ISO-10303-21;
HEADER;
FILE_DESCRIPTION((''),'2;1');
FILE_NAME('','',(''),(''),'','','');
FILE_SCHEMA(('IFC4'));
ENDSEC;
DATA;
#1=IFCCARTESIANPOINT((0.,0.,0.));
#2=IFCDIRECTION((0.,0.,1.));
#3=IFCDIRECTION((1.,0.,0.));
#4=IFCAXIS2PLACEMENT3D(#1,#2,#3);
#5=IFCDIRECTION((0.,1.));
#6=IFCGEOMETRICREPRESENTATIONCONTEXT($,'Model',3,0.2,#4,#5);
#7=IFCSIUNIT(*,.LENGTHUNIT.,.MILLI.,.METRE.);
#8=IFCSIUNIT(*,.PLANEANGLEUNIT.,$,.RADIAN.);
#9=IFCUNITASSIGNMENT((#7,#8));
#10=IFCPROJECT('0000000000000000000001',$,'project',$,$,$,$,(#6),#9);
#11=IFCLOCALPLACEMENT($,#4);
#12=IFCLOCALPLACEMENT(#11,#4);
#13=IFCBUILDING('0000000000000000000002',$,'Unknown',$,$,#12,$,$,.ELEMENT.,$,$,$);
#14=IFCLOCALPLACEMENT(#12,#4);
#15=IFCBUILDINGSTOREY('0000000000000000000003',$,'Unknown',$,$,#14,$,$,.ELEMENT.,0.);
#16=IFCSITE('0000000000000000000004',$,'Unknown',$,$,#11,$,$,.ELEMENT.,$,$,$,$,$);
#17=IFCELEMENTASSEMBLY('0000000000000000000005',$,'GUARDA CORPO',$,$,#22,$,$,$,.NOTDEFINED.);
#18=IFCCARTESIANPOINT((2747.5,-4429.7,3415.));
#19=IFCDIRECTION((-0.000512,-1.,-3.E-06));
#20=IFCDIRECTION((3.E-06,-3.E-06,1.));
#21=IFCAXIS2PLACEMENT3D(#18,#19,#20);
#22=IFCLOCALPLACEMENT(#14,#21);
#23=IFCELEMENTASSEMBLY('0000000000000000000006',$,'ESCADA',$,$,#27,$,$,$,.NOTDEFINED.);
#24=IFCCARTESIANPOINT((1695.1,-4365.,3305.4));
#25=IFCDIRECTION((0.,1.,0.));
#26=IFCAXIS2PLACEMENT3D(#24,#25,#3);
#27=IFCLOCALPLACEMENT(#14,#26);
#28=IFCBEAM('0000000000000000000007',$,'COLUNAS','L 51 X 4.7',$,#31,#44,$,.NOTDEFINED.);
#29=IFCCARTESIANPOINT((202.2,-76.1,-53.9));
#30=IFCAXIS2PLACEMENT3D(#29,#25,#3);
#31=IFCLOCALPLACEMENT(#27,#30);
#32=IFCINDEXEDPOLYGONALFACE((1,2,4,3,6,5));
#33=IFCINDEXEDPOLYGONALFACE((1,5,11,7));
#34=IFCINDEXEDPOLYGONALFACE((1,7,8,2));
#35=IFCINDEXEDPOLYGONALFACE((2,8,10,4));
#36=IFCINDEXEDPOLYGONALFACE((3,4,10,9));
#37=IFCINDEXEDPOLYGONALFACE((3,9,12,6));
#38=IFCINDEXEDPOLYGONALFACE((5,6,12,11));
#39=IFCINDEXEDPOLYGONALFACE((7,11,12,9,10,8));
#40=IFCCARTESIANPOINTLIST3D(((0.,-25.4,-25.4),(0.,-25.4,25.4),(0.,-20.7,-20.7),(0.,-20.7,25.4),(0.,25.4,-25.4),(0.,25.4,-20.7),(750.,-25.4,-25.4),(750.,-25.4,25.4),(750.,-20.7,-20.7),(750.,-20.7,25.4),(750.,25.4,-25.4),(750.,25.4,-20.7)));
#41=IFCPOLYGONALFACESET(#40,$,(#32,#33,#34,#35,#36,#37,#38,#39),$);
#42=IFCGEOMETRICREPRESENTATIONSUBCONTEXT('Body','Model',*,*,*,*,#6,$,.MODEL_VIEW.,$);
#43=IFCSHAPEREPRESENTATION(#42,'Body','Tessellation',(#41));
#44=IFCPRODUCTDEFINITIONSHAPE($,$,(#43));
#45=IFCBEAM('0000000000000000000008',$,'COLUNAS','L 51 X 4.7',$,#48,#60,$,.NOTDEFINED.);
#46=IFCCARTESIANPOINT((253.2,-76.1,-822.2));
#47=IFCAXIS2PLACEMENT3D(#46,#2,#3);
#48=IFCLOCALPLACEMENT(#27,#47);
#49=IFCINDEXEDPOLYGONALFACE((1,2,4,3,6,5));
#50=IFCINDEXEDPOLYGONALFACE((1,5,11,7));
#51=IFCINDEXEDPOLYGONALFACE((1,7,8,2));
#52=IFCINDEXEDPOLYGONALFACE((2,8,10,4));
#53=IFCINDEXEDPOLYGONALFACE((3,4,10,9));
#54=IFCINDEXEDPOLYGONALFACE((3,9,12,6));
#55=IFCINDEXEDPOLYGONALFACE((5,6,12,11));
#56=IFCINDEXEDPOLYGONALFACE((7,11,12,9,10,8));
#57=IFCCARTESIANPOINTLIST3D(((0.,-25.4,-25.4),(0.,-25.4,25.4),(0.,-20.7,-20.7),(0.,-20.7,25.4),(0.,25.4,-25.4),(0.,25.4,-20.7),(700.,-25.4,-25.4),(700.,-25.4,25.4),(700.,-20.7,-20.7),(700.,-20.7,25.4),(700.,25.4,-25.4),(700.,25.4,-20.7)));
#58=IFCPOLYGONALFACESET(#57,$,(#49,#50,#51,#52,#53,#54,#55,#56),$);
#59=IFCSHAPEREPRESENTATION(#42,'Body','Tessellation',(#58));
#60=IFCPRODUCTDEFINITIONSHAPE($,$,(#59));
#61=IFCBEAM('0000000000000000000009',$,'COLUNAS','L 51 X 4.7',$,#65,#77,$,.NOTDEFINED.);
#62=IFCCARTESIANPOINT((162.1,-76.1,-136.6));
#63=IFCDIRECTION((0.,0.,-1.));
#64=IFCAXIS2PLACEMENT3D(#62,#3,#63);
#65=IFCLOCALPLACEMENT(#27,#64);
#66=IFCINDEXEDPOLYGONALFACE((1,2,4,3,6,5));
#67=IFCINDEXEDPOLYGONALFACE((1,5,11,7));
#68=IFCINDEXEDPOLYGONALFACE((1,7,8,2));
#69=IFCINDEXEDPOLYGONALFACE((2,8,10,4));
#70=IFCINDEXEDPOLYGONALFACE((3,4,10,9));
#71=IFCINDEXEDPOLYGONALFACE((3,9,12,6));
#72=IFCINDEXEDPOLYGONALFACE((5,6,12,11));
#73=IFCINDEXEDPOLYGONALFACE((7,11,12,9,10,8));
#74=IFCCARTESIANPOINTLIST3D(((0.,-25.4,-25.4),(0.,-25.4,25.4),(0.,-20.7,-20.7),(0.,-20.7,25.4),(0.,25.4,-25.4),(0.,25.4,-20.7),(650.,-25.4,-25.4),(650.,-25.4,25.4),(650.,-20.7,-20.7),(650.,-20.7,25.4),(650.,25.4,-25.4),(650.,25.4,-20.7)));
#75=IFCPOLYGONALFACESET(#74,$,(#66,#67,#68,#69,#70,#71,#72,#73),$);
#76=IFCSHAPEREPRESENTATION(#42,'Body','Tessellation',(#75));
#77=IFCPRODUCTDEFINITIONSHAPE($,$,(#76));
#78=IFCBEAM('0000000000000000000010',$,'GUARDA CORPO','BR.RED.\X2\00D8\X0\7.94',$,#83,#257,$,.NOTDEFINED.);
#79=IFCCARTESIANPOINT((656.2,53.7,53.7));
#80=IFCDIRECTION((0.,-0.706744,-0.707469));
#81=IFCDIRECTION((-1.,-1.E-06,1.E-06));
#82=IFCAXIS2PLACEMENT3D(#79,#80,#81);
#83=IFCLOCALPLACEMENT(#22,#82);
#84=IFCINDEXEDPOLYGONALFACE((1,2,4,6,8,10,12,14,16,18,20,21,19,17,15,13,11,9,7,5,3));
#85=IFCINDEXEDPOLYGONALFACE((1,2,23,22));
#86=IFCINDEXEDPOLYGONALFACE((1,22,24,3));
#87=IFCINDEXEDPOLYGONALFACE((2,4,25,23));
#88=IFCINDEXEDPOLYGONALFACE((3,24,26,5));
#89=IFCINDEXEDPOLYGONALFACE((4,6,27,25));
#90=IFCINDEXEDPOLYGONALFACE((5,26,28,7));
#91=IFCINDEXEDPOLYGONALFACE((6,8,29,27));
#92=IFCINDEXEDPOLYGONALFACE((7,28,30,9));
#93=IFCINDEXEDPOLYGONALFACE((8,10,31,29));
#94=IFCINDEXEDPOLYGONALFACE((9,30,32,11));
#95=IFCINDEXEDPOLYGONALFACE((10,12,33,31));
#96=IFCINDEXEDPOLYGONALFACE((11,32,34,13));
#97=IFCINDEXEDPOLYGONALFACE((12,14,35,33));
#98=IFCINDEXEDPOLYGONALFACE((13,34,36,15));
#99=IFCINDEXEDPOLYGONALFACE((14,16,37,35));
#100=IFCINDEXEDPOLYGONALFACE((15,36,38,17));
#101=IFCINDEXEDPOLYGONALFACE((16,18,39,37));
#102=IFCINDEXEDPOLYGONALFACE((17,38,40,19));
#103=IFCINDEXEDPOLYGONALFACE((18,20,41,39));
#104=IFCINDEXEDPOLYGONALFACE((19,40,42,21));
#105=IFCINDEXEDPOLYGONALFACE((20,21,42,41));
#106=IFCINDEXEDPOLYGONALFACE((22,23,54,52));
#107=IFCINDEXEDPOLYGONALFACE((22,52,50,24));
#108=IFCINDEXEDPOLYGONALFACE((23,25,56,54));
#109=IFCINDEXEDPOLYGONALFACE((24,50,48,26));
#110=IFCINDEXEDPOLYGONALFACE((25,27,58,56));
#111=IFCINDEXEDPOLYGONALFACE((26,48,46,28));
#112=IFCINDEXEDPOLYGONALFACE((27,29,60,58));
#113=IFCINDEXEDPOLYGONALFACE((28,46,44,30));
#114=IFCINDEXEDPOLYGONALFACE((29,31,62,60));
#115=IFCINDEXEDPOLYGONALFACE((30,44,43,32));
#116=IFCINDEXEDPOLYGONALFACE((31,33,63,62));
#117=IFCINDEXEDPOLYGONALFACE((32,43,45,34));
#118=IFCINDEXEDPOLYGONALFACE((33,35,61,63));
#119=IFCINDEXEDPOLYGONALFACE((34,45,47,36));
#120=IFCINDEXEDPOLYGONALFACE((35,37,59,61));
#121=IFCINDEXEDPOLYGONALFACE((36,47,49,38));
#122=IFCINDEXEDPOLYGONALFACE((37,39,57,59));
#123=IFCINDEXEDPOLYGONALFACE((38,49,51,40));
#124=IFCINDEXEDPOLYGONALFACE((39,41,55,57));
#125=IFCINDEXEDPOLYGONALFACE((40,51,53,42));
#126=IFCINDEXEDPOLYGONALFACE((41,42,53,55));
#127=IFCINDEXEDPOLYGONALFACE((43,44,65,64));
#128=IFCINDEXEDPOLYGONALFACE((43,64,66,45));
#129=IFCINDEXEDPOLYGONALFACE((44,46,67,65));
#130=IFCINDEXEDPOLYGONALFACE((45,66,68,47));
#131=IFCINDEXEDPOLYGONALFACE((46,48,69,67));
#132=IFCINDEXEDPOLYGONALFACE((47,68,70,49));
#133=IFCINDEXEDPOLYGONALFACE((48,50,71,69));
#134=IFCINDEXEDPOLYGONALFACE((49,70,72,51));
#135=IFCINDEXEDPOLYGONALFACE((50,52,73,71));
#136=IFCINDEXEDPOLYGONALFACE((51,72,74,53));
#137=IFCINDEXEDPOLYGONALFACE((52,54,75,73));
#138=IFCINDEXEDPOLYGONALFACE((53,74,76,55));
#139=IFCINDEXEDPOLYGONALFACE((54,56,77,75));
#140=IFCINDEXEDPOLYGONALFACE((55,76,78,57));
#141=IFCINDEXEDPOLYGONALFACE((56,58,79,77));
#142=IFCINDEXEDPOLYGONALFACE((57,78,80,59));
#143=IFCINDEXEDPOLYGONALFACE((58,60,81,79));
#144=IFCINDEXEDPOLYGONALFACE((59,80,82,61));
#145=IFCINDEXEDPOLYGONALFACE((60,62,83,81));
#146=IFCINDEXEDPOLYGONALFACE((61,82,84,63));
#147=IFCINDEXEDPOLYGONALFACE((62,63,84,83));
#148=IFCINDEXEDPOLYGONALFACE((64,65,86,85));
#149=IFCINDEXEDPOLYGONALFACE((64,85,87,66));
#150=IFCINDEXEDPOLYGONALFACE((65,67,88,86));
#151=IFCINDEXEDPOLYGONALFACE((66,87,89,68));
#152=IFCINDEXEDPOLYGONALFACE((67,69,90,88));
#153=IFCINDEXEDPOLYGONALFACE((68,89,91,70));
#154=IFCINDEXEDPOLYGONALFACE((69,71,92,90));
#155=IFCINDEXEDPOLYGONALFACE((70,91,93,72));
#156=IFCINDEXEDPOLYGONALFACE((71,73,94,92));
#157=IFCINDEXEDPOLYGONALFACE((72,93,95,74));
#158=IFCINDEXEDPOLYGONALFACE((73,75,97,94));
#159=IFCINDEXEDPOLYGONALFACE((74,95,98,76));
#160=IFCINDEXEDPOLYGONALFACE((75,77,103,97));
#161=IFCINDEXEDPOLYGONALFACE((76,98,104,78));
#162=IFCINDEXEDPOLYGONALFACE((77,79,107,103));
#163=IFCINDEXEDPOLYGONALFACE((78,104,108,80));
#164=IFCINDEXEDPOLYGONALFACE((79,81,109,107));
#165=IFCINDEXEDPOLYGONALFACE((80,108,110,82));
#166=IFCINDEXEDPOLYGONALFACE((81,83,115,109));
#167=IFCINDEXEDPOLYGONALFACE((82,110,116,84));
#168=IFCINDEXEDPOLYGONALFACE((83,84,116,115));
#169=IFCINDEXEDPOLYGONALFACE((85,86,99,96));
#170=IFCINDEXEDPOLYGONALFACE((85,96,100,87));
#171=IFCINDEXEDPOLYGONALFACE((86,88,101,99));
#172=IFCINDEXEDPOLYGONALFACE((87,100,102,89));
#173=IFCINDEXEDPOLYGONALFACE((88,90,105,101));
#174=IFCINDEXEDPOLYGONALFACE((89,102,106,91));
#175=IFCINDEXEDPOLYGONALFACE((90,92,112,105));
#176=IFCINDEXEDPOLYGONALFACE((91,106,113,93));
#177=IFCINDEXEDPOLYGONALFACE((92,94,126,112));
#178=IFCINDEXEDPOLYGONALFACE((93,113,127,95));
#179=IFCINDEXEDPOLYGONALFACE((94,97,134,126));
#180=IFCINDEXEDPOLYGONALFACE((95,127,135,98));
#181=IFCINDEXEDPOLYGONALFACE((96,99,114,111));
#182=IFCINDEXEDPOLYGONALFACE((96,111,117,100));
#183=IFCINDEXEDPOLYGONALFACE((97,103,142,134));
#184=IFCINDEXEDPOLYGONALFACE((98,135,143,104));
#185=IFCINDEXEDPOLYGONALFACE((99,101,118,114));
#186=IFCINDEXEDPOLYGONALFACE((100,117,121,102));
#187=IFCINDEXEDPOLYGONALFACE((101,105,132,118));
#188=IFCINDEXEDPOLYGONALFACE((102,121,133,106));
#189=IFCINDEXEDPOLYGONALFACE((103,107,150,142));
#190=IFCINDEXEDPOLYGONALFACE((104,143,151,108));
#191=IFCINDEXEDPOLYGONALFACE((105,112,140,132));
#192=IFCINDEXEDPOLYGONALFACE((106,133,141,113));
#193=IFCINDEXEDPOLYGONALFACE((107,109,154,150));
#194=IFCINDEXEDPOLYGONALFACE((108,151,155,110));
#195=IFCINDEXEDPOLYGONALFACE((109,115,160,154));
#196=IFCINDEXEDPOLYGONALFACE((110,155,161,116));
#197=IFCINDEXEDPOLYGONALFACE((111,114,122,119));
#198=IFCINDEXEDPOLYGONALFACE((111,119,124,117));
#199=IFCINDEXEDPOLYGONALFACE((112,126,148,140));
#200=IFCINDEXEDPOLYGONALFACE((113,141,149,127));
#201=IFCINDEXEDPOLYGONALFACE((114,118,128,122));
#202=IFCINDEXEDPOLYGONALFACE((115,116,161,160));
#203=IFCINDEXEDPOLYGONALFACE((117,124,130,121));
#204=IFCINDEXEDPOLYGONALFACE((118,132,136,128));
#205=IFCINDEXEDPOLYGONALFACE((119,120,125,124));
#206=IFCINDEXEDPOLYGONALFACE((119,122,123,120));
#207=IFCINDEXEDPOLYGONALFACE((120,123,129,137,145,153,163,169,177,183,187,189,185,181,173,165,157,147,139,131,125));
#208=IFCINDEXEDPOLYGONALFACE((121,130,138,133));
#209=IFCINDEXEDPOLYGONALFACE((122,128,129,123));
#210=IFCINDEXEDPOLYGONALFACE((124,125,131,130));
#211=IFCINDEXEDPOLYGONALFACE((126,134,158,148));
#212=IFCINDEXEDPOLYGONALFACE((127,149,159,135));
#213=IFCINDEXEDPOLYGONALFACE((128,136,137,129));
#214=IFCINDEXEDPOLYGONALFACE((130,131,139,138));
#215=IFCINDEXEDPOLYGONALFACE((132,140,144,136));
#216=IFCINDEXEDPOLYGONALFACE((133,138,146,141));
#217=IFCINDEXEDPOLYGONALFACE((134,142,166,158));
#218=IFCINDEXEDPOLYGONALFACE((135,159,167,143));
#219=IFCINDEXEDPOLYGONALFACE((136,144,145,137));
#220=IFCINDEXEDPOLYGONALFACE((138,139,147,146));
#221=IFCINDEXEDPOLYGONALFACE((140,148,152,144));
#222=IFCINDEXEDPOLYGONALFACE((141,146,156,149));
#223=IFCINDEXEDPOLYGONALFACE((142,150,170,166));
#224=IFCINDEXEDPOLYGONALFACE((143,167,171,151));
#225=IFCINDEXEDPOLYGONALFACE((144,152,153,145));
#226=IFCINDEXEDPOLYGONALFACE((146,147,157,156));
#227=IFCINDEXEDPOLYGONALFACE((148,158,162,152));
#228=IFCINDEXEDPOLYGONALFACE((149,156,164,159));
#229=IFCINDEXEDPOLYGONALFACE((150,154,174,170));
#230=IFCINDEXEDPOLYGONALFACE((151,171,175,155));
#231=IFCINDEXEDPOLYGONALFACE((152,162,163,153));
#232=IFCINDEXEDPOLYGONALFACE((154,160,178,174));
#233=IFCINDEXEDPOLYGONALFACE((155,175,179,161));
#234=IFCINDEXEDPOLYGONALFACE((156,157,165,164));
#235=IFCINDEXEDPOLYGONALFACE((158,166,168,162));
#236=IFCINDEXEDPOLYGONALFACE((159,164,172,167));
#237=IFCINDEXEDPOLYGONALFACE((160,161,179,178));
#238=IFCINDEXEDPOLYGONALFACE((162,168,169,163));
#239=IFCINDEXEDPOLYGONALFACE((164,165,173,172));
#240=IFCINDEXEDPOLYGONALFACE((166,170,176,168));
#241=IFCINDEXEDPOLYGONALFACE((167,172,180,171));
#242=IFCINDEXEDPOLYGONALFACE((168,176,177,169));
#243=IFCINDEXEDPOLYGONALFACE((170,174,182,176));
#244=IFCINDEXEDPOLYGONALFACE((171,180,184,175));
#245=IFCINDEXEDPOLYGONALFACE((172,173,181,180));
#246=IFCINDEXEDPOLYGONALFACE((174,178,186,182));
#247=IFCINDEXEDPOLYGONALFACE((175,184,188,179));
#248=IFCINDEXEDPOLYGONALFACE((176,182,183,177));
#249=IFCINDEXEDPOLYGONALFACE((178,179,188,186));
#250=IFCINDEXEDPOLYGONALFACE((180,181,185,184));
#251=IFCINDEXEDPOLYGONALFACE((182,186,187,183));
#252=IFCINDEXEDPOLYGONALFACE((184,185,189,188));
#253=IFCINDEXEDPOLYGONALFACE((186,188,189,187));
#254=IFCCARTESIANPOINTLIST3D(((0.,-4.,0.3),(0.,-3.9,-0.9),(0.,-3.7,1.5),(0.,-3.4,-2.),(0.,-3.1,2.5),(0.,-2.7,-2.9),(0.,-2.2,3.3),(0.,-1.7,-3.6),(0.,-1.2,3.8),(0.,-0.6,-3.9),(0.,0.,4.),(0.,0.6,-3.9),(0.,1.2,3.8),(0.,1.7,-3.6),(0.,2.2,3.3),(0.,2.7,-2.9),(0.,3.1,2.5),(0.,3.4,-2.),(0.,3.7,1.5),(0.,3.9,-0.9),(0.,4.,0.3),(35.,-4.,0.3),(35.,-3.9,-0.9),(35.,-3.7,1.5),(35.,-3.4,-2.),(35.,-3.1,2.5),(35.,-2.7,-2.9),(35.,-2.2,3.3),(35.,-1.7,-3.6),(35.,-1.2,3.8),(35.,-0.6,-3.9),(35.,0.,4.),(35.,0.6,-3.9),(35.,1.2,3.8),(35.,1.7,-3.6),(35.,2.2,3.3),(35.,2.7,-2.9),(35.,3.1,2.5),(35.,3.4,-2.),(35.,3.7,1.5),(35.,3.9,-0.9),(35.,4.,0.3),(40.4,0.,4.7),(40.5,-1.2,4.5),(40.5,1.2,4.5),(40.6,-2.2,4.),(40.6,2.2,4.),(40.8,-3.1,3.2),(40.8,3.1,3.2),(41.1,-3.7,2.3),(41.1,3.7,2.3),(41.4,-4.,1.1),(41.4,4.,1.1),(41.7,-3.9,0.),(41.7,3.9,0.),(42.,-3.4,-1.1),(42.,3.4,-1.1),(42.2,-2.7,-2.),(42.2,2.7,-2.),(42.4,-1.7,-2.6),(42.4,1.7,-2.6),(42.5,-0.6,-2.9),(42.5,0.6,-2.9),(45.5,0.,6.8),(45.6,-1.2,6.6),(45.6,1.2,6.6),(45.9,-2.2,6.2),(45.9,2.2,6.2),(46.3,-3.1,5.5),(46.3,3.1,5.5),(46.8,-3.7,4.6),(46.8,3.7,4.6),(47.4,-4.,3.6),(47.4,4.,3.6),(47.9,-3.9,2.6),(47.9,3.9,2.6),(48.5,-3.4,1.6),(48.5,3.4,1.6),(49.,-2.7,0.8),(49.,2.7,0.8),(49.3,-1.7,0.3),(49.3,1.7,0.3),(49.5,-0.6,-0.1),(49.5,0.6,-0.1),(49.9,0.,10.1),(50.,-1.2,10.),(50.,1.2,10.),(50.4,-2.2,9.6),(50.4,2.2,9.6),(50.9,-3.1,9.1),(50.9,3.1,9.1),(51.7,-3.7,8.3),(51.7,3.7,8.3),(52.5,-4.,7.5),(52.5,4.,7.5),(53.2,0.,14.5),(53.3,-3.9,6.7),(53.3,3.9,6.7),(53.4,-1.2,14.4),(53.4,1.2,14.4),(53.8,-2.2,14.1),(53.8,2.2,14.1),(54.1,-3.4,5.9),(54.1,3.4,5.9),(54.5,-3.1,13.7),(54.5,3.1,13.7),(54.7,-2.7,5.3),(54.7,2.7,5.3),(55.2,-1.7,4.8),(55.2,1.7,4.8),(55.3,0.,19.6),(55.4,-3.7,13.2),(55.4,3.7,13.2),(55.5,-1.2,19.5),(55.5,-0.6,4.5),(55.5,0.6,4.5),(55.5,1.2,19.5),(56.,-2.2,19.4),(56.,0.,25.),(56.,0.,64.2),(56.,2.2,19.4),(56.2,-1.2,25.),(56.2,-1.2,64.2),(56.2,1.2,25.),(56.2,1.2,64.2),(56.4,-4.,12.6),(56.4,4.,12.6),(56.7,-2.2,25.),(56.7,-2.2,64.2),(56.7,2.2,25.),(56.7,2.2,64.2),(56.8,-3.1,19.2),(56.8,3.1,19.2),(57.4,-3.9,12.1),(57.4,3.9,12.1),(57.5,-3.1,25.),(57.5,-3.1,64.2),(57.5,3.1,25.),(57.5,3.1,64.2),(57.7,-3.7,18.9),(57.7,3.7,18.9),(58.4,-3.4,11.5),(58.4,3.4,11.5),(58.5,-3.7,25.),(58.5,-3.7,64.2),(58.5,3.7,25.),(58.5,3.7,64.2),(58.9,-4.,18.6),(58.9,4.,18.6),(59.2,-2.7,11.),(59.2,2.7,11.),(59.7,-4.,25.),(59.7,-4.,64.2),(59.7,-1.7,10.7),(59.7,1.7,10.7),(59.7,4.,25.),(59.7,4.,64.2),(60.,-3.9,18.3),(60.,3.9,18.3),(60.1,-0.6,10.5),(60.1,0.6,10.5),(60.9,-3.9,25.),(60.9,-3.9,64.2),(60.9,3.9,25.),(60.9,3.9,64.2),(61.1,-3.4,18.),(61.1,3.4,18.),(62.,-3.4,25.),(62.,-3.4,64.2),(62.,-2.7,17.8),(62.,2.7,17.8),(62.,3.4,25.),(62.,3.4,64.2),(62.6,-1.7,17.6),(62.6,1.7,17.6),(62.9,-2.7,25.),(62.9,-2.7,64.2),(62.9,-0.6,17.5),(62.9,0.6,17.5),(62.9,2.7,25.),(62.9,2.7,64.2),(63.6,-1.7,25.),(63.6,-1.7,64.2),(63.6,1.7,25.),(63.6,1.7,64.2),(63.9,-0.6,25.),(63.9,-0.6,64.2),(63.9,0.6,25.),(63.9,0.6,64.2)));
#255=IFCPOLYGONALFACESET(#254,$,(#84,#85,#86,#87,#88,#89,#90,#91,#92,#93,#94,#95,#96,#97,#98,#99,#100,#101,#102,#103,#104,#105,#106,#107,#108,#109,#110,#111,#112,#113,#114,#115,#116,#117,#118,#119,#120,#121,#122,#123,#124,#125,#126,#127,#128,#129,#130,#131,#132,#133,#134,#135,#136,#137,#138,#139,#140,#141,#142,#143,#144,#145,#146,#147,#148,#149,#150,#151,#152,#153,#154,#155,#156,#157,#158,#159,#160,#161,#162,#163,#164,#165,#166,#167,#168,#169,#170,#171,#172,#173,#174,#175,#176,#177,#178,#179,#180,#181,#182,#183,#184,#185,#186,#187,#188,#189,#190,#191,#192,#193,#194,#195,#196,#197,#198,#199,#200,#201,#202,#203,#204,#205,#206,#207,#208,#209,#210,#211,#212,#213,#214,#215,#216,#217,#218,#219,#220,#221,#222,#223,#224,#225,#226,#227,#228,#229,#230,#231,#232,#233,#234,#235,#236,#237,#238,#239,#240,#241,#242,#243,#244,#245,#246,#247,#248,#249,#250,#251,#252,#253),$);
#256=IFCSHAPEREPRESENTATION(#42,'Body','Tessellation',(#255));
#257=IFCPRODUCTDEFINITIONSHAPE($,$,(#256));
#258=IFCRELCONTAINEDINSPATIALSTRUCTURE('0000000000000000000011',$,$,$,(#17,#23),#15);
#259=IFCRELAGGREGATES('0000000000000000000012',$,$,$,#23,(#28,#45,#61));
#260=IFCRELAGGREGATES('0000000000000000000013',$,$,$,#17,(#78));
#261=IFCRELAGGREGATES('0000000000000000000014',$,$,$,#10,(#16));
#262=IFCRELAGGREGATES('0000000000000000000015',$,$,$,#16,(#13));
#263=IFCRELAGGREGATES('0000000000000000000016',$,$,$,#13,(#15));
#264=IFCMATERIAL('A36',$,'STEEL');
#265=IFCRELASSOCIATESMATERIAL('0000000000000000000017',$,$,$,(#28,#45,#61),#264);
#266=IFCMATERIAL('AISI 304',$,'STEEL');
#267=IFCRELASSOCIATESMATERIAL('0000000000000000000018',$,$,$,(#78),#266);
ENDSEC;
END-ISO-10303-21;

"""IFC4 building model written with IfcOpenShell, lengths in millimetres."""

from ifc_helpers import new_model, entity, si_unit, direction, frame, origin_with_axes, place, context, subcontext, project, spatial, line, indexed_curve, outline, extrude, material, element, aggregate, save


model = new_model("IFC4")

# Units and contexts
model_context = context("Model", 3, precision=0.2, world=origin_with_axes(), true_north=direction((0.0, 1.0)))
body_context = subcontext(model_context, "Body", "Model", "MODEL_VIEW")
ifc_project = project(units=[si_unit("LENGTHUNIT", "METRE", prefix="MILLI"), si_unit("PLANEANGLEUNIT", "RADIAN")], contexts=[model_context])

# Site, building, storey
site_placement = place(None, origin_with_axes())
site = spatial("IfcSite", under=ifc_project, at=site_placement, Name="Unknown", CompositionType="ELEMENT")
building_placement = place(site_placement, origin_with_axes())
building = spatial("IfcBuilding", under=site, at=building_placement, Name="Unknown", CompositionType="ELEMENT")
storey_placement = place(building_placement, origin_with_axes())
storey = spatial("IfcBuildingStorey", under=building, at=storey_placement, Name="Unknown", CompositionType="ELEMENT", Elevation=0.0)

# Element assembly
assembly_1_placement = place(storey_placement, frame((2747.5, -4429.7, 3415.0), z_axis=(-0.000512, -1.0, -0.000003), x_axis=(0.000003, -0.000003, 1.0)))
assembly_1 = element("IfcElementAssembly", 1, at=assembly_1_placement, inside=storey, Name="GUARDA CORPO", PredefinedType="NOTDEFINED")
ifc_material_1 = material(Name="AISI 304", Category="STEEL")

# Element assembly, beams
assembly_2_placement = place(storey_placement, frame((1695.1, -4365.0, 3305.4), z_axis=(0.0, 1.0, 0.0), x_axis=(1.0, 0.0, 0.0)))
assembly_2 = element("IfcElementAssembly", 2, at=assembly_2_placement, inside=storey, Name="ESCADA", PredefinedType="NOTDEFINED")
ifc_material_2 = material(Name="A36", Category="STEEL")
beam_1_placement = place(assembly_2_placement, frame((202.2, -76.1, -53.9), z_axis=(0.0, 1.0, 0.0), x_axis=(1.0, 0.0, 0.0)))
beam_1 = element("IfcBeam", 3, at=beam_1_placement, material=ifc_material_2, Name="COLUNAS", Description="L 51 X 4.7", PredefinedType="NOTDEFINED", context=body_context, shape_type="SolidModel", body=[
    extrude(outline(indexed_curve([(-25.4, -25.4), (25.4, -25.4), (25.4, -20.7), (-20.7, -20.7), (-20.7, 25.4), (-25.4, 25.4)], segments=[line(1, 2, 3, 4, 5, 6, 1)])), frame((0.0, 0.0, 0.0), z_axis=(-1.0, 0.0, 0.0), x_axis=(0.0, 0.0, 1.0)), (0.0, 0.0, -1.0), 750.0),
])
beam_2_placement = place(assembly_2_placement, frame((253.2, -76.1, -822.2), z_axis=(0.0, 0.0, 1.0), x_axis=(1.0, 0.0, 0.0)))
beam_2 = element("IfcBeam", 4, at=beam_2_placement, material=ifc_material_2, Name="COLUNAS", Description="L 51 X 4.7", PredefinedType="NOTDEFINED", context=body_context, shape_type="SolidModel", body=[
    extrude(outline(indexed_curve([(-25.4, -25.4), (25.4, -25.4), (25.4, -20.7), (-20.7, -20.7), (-20.7, 25.4), (-25.4, 25.4)], segments=[line(1, 2, 3, 4, 5, 6, 1)])), frame((0.0, 0.0, 0.0), z_axis=(-1.0, 0.0, 0.0), x_axis=(0.0, 0.0, 1.0)), (0.0, 0.0, -1.0), 700.0),
])
beam_3_placement = place(assembly_2_placement, frame((162.1, -76.1, -136.6), z_axis=(1.0, 0.0, 0.0), x_axis=(0.0, 0.0, -1.0)))
beam_3 = element("IfcBeam", 5, at=beam_3_placement, material=ifc_material_2, Name="COLUNAS", Description="L 51 X 4.7", PredefinedType="NOTDEFINED", context=body_context, shape_type="SolidModel", body=[
    extrude(outline(indexed_curve([(-25.4, -25.4), (25.4, -25.4), (25.4, -20.7), (-20.7, -20.7), (-20.7, 25.4), (-25.4, 25.4)], segments=[line(1, 2, 3, 4, 5, 6, 1)])), frame((0.0, 0.0, 0.0), z_axis=(-1.0, 0.0, 0.0), x_axis=(0.0, 0.0, 1.0)), (0.0, 0.0, -1.0), 650.0),
])

# Beam
beam_4_placement = place(assembly_1_placement, frame((656.2, 53.7, 53.7), z_axis=(0.0, -0.706744, -0.707469), x_axis=(-1.0, -0.000001, 0.000001)))
beam_4 = element("IfcBeam", 6, at=beam_4_placement, material=ifc_material_1, Name="GUARDA CORPO", Description="BR.RED.Ø7.94", PredefinedType="NOTDEFINED", context=body_context, shape_type="SolidModel", body=[
    entity("IfcSweptDiskSolid", entity("IfcIndexedPolyCurve", entity("IfcCartesianPointList3D", [[0.0, 0.0, 0.0], [35.0, 0.0, 0.0], [52.7, 0.0, 7.3], [60.0, 0.0, 25.0], [60.0, 0.0, 64.2]]), [entity("IfcLineIndex", [1, 2]), entity("IfcArcIndex", [2, 3, 4]), entity("IfcLineIndex", [4, 5])]), 4.0),
])

aggregate(assembly_2, [beam_1, beam_2, beam_3])
aggregate(assembly_1, [beam_4])

save(model, "model.ifc")
